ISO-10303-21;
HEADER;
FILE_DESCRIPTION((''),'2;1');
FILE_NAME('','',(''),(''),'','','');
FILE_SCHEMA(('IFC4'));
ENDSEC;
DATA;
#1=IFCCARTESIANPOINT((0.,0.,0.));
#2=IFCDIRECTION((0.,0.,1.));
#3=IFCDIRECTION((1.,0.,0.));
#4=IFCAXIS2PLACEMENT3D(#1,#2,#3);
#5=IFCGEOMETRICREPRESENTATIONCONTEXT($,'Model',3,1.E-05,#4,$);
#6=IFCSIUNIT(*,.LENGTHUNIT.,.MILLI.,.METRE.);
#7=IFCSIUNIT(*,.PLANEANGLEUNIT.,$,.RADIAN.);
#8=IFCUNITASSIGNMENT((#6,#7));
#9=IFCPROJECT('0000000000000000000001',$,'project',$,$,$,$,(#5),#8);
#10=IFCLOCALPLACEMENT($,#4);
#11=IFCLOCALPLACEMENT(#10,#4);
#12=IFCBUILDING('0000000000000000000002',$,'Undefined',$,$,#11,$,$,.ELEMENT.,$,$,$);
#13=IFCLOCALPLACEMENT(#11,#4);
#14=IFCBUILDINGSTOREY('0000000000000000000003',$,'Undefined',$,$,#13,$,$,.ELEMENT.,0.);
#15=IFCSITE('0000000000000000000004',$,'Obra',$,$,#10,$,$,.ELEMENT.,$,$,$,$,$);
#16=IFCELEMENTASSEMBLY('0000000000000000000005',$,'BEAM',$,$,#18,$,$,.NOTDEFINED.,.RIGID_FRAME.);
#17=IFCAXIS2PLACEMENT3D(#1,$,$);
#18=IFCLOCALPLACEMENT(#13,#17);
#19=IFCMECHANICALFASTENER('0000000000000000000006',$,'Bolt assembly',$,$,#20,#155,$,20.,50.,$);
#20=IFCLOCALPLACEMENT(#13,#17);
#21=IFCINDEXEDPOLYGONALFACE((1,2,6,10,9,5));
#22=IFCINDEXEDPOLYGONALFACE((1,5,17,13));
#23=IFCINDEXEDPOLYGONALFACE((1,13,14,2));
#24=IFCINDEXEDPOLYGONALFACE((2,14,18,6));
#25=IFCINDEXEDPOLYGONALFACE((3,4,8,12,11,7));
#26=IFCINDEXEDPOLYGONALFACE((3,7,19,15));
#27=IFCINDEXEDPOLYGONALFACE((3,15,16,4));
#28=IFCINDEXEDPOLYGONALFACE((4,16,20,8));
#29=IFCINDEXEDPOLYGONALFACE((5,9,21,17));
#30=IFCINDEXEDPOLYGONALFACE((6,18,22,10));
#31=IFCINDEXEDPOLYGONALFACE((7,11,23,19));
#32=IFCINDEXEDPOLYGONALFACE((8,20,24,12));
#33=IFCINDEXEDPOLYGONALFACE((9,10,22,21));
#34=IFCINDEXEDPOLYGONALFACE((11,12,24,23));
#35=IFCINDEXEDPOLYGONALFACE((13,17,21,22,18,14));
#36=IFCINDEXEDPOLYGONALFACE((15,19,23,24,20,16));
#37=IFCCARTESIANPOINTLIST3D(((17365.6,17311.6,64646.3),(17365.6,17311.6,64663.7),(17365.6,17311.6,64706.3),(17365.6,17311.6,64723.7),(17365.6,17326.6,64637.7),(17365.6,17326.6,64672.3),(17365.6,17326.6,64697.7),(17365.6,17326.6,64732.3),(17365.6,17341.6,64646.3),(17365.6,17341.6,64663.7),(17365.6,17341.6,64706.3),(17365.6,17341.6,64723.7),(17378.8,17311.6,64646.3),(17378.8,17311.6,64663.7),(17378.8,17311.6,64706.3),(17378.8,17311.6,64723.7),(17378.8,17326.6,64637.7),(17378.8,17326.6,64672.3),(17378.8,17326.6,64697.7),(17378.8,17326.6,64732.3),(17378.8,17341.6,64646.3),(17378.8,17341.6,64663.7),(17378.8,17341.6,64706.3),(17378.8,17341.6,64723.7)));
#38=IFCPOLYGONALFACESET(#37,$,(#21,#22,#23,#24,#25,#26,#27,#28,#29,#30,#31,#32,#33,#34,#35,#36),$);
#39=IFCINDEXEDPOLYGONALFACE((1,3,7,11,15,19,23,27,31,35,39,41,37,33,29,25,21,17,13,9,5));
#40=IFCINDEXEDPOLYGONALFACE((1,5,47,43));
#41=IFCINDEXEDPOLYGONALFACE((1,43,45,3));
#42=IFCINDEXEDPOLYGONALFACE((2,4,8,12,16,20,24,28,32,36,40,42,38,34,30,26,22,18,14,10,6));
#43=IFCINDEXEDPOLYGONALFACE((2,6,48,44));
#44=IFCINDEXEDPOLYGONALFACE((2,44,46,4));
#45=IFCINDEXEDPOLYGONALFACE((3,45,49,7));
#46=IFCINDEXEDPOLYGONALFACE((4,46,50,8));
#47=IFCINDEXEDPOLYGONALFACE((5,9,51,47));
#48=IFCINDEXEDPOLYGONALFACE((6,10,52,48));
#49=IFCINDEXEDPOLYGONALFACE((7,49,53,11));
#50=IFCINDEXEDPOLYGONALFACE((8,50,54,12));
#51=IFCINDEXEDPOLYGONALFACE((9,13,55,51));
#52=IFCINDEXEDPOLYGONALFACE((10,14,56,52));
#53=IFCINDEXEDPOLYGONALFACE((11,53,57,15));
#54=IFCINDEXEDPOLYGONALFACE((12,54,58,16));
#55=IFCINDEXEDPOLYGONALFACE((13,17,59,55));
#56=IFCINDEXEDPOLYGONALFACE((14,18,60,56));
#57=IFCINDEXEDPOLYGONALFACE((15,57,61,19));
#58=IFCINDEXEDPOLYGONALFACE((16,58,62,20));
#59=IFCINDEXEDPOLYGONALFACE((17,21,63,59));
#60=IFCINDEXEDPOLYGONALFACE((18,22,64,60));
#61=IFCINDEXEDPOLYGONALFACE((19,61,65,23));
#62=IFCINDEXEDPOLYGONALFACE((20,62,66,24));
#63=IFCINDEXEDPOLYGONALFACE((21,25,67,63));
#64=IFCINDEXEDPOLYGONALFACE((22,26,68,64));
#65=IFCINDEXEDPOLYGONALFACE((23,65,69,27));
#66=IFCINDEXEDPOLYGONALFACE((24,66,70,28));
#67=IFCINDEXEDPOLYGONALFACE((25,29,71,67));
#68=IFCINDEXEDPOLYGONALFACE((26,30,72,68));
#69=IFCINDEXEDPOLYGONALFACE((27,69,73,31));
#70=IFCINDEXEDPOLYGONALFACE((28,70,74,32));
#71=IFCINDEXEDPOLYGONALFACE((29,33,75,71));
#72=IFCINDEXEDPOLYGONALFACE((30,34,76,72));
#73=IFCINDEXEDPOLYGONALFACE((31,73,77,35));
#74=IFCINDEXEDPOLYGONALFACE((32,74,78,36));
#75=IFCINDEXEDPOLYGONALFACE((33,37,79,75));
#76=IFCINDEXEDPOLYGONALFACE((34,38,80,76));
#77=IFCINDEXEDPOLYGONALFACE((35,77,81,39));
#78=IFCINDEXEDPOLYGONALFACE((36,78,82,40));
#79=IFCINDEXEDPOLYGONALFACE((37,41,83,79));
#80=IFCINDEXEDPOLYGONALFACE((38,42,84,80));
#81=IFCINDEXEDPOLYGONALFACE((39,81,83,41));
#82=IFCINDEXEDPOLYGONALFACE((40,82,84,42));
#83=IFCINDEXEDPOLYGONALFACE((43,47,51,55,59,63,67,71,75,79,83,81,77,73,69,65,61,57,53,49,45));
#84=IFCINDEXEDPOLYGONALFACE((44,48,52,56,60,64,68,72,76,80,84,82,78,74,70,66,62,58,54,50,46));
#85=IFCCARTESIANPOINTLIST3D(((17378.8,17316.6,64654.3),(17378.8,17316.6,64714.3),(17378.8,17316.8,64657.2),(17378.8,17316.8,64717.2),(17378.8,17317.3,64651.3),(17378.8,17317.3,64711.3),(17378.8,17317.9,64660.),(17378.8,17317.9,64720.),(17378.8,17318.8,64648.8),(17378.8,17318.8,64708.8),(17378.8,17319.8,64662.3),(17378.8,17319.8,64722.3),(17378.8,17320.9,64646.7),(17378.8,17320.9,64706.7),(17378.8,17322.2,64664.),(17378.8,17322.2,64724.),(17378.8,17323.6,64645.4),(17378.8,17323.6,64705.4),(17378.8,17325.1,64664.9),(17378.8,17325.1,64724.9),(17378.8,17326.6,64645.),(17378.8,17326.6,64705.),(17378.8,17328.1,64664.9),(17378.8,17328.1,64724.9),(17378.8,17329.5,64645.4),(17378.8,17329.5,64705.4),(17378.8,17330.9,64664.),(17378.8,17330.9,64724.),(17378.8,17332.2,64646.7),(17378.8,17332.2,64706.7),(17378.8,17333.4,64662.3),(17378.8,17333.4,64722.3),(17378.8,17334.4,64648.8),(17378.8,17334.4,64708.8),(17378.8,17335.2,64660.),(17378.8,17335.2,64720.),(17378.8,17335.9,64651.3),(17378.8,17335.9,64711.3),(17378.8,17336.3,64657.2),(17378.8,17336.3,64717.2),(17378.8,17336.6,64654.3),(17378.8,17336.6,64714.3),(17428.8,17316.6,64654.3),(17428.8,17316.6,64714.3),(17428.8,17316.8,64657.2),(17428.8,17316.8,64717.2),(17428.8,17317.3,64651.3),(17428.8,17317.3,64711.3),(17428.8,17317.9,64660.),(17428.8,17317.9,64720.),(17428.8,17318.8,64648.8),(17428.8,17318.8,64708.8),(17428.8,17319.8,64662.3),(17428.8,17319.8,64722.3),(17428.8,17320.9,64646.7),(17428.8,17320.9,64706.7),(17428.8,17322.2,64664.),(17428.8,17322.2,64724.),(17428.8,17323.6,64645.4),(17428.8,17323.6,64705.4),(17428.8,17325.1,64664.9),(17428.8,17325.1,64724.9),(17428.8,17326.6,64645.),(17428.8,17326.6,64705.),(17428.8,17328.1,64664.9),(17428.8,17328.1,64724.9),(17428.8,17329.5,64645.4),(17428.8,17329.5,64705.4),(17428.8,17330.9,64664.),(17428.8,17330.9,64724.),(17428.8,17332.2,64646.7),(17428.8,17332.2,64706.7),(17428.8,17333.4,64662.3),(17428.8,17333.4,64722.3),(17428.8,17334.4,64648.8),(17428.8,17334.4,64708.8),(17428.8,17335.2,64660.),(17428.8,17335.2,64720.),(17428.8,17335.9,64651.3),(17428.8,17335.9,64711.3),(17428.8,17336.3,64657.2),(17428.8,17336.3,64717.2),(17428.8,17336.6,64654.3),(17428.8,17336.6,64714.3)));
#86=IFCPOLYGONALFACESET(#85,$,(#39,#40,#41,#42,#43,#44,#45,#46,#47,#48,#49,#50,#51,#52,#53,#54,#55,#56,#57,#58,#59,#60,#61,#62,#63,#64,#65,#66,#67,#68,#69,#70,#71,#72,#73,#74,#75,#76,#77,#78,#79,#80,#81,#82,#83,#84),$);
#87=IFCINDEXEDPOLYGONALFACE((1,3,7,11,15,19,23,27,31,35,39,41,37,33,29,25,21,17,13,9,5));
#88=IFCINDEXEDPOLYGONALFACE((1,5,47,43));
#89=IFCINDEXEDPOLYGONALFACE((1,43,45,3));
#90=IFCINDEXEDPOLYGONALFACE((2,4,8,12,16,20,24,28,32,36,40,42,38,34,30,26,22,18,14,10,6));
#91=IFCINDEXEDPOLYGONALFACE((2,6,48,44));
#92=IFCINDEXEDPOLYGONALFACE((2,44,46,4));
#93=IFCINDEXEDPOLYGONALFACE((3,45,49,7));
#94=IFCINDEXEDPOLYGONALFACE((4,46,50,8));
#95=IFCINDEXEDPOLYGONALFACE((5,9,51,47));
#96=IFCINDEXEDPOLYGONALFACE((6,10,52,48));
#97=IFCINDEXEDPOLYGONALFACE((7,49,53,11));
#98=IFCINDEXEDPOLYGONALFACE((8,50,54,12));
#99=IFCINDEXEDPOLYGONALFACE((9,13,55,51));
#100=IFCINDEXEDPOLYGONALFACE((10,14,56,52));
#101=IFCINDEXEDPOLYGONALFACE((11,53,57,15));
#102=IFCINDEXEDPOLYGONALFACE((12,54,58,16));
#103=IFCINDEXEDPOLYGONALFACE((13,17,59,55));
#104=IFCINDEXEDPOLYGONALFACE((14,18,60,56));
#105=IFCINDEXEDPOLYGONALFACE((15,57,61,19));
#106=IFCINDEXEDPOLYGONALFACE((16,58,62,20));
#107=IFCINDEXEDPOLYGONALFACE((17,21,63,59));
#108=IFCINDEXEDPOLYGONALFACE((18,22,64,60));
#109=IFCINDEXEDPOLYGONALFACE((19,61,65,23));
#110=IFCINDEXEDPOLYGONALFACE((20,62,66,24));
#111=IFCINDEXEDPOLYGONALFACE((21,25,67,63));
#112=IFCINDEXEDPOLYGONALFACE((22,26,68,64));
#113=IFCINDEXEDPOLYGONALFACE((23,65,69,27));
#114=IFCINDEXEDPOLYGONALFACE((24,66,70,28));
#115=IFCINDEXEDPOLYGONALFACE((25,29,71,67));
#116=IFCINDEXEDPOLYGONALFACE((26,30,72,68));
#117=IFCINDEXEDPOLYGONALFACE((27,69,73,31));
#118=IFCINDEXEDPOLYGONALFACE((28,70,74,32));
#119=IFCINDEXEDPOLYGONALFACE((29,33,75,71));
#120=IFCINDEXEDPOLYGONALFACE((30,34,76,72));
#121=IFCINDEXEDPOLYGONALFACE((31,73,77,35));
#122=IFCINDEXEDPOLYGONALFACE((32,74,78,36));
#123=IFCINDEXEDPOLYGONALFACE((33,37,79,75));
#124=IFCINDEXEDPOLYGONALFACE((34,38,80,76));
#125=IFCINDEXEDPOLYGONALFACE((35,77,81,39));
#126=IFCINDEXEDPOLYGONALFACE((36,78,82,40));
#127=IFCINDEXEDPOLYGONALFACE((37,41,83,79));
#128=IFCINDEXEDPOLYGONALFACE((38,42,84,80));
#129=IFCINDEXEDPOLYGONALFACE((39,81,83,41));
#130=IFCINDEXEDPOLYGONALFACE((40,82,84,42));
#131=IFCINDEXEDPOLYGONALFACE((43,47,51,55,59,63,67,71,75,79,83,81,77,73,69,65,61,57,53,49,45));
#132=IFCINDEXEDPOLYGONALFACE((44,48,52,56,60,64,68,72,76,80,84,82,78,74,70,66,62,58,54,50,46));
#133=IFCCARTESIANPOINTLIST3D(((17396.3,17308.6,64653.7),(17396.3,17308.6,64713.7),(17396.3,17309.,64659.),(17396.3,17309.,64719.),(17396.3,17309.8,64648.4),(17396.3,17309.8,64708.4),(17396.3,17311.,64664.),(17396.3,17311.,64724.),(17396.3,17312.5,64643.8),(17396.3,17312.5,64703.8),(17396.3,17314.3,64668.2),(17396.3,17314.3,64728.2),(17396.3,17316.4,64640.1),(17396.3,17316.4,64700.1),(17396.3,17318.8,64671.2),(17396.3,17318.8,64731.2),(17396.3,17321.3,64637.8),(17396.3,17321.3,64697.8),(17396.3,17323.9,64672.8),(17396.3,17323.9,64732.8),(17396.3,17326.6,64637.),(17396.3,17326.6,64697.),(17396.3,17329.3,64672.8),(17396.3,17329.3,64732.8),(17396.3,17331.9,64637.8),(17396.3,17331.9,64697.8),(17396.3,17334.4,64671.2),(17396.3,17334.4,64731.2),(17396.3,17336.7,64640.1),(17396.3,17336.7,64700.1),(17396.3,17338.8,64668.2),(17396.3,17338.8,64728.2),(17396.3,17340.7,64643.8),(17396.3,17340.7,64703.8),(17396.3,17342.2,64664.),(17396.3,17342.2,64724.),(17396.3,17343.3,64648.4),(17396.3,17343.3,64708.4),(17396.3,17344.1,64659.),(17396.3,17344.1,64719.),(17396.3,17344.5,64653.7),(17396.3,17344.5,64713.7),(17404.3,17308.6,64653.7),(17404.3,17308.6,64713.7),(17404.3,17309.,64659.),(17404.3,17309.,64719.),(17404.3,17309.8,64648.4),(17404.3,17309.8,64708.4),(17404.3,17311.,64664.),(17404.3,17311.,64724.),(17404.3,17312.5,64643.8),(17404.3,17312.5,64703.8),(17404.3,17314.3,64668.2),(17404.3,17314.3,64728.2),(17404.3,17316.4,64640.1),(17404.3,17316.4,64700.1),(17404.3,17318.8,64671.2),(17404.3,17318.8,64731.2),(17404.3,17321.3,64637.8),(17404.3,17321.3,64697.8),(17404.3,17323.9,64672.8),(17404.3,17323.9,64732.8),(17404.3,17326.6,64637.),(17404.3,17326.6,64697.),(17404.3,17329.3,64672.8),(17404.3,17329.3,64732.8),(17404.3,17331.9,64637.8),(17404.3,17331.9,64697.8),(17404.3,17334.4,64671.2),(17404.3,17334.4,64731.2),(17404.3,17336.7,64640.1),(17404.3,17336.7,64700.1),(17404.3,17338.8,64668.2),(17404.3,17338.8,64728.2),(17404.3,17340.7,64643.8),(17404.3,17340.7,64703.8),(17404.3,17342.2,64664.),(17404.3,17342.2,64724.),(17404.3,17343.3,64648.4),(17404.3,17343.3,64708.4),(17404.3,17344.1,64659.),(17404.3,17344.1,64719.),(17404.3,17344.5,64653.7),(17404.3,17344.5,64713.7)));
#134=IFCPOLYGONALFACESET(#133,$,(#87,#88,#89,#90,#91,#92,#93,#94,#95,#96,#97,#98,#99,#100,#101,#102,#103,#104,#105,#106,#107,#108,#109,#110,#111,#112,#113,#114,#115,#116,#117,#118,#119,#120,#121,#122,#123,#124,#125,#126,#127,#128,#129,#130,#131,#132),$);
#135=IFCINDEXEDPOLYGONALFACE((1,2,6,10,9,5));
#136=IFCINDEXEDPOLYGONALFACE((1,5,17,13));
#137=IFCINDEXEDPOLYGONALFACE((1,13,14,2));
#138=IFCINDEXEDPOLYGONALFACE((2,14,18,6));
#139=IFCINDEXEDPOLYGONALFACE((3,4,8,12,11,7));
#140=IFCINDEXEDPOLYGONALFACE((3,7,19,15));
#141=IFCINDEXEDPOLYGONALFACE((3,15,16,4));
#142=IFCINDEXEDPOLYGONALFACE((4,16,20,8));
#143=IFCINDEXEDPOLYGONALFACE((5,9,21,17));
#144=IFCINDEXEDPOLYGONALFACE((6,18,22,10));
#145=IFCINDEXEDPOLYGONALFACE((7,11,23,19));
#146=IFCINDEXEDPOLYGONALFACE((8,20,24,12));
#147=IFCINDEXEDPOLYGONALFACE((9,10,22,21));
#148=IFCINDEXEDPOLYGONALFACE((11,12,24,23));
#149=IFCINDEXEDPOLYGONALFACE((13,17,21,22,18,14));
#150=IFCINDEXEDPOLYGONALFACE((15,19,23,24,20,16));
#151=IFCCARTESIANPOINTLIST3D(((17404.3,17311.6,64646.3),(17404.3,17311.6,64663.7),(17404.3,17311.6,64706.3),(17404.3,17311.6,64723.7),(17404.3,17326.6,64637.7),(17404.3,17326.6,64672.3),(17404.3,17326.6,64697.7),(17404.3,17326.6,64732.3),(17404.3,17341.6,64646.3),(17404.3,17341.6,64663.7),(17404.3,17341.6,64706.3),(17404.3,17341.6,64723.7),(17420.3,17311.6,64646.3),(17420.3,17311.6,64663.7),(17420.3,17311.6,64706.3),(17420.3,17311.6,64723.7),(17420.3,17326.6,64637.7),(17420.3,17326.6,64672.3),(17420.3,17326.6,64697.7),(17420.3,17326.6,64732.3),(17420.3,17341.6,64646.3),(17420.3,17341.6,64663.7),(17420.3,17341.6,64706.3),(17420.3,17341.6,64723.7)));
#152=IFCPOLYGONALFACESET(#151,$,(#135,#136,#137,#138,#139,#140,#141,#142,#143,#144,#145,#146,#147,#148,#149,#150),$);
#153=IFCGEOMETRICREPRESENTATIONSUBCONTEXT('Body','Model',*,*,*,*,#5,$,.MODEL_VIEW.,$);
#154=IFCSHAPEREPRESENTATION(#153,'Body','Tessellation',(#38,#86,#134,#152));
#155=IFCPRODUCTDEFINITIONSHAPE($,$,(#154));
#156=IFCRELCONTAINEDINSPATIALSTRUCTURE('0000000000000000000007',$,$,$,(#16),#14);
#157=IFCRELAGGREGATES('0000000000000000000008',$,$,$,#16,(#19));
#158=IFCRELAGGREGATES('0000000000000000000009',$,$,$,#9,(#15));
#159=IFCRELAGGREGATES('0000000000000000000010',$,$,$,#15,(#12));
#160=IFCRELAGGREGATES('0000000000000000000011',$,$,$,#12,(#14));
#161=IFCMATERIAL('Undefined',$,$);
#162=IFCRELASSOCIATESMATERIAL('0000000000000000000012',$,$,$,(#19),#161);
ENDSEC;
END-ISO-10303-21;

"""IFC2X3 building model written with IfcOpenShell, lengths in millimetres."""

from ifc_helpers import new_model, si_unit, frame, origin_with_axes, origin_2d_with_axis, place, context, subcontext, project, spatial, polyline, circle, outline, extrude, source, transform, mapped, material, element, aggregate, save


model = new_model("IFC2X3")

# Units and contexts
model_context = context("Model", 3, precision=1e-05, world=origin_with_axes())
body_context = subcontext(model_context, "Body", "Model", "MODEL_VIEW")
ifc_project = project(units=[si_unit("LENGTHUNIT", "METRE", prefix="MILLI"), si_unit("PLANEANGLEUNIT", "RADIAN")], contexts=[model_context])

# Site, building, storey
site_placement = place(None, origin_with_axes())
site = spatial("IfcSite", under=ifc_project, at=site_placement, Name="Obra", CompositionType="ELEMENT")
building_placement = place(site_placement, origin_with_axes())
building = spatial("IfcBuilding", under=site, at=building_placement, Name="Undefined", CompositionType="ELEMENT")
storey_placement = place(building_placement, origin_with_axes())
storey = spatial("IfcBuildingStorey", under=building, at=storey_placement, Name="Undefined", CompositionType="ELEMENT", Elevation=0.0)

# Shared definitions
ifc_material = material(Name="Undefined")

# Element assembly, mechanical fastener
assembly_1_placement = place(storey_placement, origin_with_axes())
assembly_1 = element("IfcElementAssembly", 1, at=assembly_1_placement, inside=storey, Name="BEAM", AssemblyPlace="NOTDEFINED", PredefinedType="RIGID_FRAME")
shared_shape_1 = source(origin_with_axes(), body_context, "Body", "SweptSolid", [
    extrude(outline(polyline([(17.3, 0.0), (8.7, 15.0), (-8.7, 15.0), (-17.3, 0.0), (-8.7, -15.0), (8.7, -15.0), (17.3, 0.0)])), frame((0.0, -27.0, 0.0), z_axis=(0.0, 1.0, 0.0), x_axis=(1.0, 0.0, 0.0)), (0.0, 0.0, 1.0), 13.2),
    extrude(circle(Radius=10.0, at=origin_2d_with_axis()), frame((0.0, -13.8, 0.0), z_axis=(0.0, 1.0, 0.0), x_axis=(1.0, 0.0, 0.0)), (0.0, 0.0, 1.0), 50.0),
    extrude(circle(Radius=18.0, at=origin_2d_with_axis()), frame((0.0, 3.7, 0.0), z_axis=(0.0, 1.0, 0.0), x_axis=(1.0, 0.0, 0.0)), (0.0, 0.0, 1.0), 8.0),
    extrude(outline(polyline([(17.3, 0.0), (8.7, 15.0), (-8.7, 15.0), (-17.3, 0.0), (-8.7, -15.0), (8.7, -15.0), (17.3, 0.0)])), frame((0.0, 11.7, 0.0), z_axis=(0.0, 1.0, 0.0), x_axis=(1.0, 0.0, 0.0)), (0.0, 0.0, 1.0), 16.0),
])
mechanical_fastener_1_placement = place(assembly_1_placement, frame((17392.6, 17366.6, 64850.0), z_axis=(0.0, -1.0, 0.0), x_axis=(0.0, 0.0, -1.0)))
mechanical_fastener_1 = element("IfcMechanicalFastener", 2, at=mechanical_fastener_1_placement, material=ifc_material, Name="Bolt assembly", NominalDiameter=20.0, NominalLength=50.0, context=body_context, shape_type="MappedRepresentation", body=[
    mapped(shared_shape_1, transform((135.0, 0.0, 40.0))),
    mapped(shared_shape_1, transform((195.0, 0.0, 40.0))),
])

aggregate(assembly_1, [mechanical_fastener_1])

save(model, "model.ifc")
